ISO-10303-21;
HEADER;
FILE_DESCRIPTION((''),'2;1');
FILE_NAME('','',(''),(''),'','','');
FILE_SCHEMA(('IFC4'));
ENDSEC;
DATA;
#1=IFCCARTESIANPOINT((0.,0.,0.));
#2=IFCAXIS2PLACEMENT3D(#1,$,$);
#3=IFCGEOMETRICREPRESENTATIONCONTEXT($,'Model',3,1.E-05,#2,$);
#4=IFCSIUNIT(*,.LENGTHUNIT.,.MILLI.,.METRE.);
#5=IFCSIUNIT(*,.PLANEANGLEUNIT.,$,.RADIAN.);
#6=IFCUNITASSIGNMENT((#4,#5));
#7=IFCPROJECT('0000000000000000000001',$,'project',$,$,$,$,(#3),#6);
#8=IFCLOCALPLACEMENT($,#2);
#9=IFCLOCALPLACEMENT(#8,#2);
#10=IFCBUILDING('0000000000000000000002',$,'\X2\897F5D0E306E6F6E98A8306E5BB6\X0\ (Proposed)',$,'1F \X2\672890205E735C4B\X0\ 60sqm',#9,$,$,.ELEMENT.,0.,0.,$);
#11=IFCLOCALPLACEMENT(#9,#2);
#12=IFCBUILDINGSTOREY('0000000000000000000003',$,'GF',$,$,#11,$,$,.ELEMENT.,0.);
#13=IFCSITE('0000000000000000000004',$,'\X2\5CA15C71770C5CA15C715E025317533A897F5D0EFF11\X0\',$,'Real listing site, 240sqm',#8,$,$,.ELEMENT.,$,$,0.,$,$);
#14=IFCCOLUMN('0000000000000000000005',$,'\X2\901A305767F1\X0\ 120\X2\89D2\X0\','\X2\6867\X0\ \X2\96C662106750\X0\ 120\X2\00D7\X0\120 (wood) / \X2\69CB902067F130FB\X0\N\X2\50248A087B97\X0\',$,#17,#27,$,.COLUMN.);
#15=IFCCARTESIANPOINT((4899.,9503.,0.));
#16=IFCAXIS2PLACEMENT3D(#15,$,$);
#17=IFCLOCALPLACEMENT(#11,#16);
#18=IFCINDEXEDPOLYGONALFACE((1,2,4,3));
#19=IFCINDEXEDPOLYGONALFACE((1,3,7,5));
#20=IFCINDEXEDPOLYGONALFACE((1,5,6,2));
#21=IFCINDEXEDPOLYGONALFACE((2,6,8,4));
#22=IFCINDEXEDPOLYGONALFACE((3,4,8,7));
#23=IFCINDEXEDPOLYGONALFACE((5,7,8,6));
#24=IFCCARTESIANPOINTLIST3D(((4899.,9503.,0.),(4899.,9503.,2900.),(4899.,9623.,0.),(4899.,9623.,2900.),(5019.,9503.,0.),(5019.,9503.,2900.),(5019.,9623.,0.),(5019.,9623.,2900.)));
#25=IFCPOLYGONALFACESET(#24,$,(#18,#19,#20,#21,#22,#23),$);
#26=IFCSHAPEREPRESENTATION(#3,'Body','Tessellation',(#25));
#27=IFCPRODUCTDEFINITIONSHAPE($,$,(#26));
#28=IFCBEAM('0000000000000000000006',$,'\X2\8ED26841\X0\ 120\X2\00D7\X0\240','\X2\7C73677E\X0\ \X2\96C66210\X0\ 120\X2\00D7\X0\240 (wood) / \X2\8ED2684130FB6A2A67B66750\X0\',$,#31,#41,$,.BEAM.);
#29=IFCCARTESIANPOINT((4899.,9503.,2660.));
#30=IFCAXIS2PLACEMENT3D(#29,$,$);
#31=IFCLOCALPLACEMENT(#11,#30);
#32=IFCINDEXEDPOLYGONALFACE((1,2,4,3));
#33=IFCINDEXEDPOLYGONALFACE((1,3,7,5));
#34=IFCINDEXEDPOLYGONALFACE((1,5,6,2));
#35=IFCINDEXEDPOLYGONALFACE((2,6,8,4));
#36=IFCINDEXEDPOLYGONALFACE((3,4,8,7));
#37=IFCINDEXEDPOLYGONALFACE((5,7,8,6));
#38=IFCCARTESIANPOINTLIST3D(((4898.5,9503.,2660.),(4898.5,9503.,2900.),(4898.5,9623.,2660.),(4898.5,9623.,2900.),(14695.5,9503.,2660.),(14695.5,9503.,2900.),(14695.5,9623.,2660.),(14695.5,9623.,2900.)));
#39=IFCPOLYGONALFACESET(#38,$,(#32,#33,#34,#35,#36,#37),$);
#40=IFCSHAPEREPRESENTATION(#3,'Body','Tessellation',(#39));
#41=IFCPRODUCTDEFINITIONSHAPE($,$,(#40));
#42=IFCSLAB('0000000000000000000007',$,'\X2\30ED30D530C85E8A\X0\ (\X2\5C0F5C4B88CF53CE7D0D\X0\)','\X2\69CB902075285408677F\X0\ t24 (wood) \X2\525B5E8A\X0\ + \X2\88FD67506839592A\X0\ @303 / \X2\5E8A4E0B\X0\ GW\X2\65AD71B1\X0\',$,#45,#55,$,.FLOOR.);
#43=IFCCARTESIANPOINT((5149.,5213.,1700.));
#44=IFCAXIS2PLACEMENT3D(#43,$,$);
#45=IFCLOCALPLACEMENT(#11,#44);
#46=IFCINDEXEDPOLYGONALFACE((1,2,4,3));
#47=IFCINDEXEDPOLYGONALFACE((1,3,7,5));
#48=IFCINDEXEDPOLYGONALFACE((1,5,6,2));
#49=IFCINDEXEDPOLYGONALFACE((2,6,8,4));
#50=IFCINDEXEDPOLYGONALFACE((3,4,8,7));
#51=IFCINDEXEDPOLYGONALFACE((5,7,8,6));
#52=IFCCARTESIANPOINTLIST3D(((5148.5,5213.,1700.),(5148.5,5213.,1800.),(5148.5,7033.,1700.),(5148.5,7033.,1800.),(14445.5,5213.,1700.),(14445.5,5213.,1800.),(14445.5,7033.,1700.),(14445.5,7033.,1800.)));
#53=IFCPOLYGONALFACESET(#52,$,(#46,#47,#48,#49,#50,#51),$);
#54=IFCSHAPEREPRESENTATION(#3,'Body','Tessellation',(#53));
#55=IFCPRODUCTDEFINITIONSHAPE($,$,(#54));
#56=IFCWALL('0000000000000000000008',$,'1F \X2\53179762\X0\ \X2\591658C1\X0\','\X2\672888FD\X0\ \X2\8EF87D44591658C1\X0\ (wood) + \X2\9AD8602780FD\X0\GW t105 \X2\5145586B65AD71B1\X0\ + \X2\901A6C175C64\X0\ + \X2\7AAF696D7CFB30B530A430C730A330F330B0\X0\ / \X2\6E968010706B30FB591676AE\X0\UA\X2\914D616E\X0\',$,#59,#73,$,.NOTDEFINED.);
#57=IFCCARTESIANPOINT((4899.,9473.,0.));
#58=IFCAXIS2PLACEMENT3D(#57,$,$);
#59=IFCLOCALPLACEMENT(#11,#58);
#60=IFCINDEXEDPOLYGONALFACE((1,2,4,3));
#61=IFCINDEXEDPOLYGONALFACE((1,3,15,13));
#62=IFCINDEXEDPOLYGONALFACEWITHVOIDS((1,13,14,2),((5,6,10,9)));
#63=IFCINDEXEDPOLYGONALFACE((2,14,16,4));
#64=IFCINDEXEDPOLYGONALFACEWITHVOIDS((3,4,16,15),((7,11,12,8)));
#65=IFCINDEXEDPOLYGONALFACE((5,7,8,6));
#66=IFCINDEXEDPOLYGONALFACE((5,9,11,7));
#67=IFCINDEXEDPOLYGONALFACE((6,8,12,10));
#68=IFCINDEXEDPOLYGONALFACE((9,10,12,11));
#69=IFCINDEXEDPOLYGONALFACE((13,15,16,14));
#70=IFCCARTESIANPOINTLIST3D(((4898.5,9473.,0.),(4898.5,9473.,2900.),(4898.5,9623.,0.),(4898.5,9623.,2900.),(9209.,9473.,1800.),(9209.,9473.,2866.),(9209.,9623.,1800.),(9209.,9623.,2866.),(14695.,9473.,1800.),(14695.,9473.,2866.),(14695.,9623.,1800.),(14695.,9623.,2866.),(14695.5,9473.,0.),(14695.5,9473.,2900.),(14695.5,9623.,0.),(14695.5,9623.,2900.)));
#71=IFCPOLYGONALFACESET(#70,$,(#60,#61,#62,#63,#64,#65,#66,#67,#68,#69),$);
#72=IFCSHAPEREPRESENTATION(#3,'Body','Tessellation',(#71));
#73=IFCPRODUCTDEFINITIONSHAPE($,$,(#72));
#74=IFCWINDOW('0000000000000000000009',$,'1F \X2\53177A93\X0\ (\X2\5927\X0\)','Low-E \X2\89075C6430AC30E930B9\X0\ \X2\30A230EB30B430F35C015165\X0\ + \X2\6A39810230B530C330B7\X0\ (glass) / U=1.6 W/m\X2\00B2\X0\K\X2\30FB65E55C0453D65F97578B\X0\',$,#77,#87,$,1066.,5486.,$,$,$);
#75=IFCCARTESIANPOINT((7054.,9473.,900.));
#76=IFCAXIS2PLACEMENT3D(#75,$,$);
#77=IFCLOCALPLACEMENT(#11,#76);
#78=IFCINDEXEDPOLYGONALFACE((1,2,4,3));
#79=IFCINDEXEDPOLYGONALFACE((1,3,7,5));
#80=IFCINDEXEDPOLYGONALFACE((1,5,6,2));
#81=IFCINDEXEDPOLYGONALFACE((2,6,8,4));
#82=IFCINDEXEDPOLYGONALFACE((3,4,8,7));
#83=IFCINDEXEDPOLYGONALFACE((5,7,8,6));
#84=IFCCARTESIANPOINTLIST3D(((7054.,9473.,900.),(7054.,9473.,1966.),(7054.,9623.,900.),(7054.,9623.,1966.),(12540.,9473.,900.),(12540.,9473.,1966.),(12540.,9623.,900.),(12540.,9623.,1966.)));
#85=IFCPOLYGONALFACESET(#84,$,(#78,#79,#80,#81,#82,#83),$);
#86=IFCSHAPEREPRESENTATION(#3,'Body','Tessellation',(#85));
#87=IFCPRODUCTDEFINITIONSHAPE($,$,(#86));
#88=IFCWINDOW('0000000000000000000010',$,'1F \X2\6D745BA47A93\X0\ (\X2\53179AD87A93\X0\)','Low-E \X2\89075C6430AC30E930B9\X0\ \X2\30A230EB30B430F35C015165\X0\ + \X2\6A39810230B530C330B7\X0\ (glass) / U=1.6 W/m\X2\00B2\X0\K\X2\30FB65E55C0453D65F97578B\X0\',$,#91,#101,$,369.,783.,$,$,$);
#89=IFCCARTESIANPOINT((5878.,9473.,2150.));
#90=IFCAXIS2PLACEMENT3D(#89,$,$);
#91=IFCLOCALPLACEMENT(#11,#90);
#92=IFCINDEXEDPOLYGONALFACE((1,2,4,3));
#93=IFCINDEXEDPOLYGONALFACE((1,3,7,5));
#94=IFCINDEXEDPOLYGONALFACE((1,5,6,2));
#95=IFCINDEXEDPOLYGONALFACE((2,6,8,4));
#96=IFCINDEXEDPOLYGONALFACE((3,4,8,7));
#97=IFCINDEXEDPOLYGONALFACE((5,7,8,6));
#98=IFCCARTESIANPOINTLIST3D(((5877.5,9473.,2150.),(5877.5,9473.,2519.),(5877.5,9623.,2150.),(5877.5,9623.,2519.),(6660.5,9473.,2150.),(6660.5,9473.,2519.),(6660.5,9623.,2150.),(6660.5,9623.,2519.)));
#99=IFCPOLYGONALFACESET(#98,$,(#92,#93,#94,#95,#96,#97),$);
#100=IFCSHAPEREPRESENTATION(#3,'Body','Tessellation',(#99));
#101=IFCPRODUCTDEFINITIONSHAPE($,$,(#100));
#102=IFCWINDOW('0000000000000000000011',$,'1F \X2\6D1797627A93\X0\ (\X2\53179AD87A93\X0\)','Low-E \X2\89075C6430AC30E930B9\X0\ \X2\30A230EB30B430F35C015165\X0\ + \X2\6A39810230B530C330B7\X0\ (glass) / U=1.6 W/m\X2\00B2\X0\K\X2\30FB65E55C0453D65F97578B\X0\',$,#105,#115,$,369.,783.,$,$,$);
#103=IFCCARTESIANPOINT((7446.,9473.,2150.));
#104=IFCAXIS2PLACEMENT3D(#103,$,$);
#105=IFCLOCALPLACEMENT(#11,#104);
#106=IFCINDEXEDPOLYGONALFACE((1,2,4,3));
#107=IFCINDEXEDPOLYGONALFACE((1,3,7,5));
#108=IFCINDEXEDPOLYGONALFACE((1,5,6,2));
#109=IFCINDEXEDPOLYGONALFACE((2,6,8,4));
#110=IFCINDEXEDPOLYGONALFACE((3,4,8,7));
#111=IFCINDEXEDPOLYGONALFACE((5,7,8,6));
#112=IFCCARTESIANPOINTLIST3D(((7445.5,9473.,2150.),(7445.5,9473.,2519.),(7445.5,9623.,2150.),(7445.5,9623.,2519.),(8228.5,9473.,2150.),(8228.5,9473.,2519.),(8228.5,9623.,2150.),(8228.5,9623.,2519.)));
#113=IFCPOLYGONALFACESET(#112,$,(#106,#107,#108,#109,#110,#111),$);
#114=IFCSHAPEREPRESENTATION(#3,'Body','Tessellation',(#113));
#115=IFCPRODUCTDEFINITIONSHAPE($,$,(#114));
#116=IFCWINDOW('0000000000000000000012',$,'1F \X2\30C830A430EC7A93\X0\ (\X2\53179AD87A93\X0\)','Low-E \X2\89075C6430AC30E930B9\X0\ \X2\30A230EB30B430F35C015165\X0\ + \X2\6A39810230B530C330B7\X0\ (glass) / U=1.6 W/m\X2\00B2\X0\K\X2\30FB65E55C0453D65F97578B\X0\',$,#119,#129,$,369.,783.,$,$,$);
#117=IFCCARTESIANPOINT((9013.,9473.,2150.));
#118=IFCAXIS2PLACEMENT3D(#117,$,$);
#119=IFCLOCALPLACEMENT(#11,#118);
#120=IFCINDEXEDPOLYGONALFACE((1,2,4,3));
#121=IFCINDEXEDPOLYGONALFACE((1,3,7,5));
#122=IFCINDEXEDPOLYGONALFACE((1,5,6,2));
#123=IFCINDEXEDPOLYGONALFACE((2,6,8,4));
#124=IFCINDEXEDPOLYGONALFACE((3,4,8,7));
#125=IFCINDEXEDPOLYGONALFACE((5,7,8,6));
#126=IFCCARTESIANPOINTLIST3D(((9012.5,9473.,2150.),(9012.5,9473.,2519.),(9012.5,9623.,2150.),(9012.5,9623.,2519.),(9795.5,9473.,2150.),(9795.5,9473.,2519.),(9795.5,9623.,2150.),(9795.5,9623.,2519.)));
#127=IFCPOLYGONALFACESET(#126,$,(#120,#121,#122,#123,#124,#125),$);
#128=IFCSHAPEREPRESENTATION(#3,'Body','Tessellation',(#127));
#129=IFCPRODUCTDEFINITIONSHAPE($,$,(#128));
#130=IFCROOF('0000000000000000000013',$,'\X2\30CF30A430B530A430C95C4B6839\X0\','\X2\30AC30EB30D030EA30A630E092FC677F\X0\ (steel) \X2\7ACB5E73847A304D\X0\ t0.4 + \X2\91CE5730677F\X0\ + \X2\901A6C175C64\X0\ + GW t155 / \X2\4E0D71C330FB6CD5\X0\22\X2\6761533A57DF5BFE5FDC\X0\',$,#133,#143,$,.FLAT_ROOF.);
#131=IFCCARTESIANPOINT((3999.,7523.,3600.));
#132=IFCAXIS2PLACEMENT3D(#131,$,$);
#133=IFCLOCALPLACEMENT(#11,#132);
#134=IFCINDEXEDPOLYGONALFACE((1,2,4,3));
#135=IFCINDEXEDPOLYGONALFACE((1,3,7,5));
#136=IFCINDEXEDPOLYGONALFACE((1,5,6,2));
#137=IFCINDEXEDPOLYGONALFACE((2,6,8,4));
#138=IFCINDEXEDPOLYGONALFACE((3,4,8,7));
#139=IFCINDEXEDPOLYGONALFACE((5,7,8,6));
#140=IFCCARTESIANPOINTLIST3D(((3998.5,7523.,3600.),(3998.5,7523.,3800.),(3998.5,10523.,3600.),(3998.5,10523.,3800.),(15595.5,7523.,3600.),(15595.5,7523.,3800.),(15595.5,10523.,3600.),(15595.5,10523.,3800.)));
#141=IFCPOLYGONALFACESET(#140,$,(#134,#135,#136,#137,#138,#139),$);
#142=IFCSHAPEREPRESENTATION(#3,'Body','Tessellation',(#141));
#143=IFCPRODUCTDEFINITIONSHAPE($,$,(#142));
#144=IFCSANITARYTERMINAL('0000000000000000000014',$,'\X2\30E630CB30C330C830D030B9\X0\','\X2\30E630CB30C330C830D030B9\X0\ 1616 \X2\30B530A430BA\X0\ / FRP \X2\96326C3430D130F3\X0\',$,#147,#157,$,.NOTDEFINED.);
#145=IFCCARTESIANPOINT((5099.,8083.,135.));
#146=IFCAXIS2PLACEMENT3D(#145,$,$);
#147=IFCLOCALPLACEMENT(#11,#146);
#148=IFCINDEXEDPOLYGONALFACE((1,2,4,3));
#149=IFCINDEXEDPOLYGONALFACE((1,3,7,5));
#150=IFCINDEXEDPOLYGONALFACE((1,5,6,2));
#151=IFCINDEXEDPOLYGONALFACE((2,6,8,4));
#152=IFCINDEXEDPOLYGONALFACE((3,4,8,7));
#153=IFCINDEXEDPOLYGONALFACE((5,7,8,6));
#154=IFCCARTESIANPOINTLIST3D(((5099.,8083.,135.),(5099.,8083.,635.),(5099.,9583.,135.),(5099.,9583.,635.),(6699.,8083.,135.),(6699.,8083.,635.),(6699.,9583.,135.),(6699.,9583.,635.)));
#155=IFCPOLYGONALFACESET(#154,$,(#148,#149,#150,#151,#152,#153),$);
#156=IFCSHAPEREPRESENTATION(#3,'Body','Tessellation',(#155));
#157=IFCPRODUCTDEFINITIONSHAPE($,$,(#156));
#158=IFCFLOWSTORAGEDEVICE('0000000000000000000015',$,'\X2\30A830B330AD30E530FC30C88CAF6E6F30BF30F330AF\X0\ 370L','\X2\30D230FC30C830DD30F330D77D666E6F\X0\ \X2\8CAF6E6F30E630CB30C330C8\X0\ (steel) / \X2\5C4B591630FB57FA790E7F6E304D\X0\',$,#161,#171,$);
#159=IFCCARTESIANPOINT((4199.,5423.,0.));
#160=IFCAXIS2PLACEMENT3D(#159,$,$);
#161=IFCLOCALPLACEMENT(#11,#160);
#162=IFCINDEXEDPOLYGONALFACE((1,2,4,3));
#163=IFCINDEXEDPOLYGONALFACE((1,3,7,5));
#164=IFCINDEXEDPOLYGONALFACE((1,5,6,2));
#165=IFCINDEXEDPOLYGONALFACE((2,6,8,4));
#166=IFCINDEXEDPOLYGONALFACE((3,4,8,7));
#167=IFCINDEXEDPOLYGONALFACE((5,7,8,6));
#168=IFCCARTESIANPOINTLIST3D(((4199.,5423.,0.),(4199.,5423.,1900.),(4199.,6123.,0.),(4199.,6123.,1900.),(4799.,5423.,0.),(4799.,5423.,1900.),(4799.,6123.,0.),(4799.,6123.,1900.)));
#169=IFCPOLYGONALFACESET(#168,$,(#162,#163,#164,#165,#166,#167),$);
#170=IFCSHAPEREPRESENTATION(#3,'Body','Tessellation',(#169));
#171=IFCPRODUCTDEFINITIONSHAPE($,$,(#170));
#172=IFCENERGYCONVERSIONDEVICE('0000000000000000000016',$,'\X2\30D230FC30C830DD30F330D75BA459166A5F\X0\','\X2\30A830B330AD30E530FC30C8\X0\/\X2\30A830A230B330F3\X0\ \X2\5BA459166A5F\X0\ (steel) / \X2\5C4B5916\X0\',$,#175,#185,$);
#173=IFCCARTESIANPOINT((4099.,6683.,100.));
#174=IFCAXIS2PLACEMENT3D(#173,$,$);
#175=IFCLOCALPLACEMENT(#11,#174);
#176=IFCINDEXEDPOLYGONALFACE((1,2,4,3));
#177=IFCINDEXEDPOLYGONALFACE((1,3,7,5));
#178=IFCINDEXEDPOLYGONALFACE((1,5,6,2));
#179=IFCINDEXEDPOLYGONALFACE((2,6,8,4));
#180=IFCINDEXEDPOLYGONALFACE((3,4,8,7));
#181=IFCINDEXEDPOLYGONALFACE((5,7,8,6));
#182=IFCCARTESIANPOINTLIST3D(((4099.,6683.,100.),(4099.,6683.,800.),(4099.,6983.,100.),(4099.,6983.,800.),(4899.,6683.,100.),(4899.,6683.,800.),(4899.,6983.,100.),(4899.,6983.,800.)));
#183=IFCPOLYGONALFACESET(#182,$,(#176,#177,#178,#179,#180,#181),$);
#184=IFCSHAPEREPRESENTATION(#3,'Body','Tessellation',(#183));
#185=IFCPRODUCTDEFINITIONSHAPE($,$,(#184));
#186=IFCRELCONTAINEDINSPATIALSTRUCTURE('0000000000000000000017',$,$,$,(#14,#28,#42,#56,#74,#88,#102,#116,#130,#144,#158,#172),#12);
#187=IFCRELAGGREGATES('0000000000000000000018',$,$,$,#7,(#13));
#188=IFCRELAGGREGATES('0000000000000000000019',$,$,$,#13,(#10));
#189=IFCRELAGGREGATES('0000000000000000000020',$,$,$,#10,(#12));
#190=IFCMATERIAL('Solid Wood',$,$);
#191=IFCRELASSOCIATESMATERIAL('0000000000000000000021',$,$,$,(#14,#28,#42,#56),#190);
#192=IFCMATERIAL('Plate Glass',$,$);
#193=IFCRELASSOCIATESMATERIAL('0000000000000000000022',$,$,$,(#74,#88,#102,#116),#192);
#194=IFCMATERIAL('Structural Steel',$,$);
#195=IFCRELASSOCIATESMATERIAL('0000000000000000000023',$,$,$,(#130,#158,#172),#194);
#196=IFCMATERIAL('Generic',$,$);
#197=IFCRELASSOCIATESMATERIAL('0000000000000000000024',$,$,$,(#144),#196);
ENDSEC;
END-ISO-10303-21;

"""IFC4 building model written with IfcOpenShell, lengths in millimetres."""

from ifc_helpers import new_model, si_unit, frame, frame_2d, origin, place, context, project, spatial, rectangle, extrude, material, element, fill, save


model = new_model("IFC4")

# Units and contexts
model_context = context("Model", 3, precision=1e-05, world=origin())
ifc_project = project(units=[si_unit("LENGTHUNIT", "METRE", prefix="MILLI"), si_unit("PLANEANGLEUNIT", "RADIAN")], contexts=[model_context])

# Site, building, storey
site_placement = place(None, origin())
site = spatial("IfcSite", under=ifc_project, at=site_placement, Name="岡山県岡山市北区西崎１", ObjectType="Real listing site, 240sqm", CompositionType="ELEMENT", RefElevation=0.0)
building_placement = place(site_placement, origin())
building = spatial("IfcBuilding", under=site, at=building_placement, Name="西崎の潮風の家 (Proposed)", ObjectType="1F 木造平屋 60sqm", CompositionType="ELEMENT", ElevationOfRefHeight=0.0, ElevationOfTerrain=0.0)
storey_placement = place(building_placement, origin())
storey = spatial("IfcBuildingStorey", under=building, at=storey_placement, Name="GF", CompositionType="ELEMENT", Elevation=0.0)

# Column
ifc_material_1 = material(Name="Solid Wood")
column_1_placement = place(storey_placement, frame((4899.0, 9503.0, 0.0)))
element("IfcColumn", 1, at=column_1_placement, inside=storey, material=ifc_material_1, Name="通し柱 120角", Description="桧 集成材 120×120 (wood) / 構造柱・N値計算", PredefinedType="COLUMN", context=model_context, shape_type="SweptSolid", body=[
    extrude(rectangle(XDim=120.0, YDim=120.0, at=frame_2d((60.0, 60.0))), frame((4899.0, 9503.0, 0.0)), (0.0, 0.0, 1.0), 2900.0),
])

# Beam
beam_1_placement = place(storey_placement, frame((4899.0, 9503.0, 2660.0)))
element("IfcBeam", 2, at=beam_1_placement, inside=storey, material=ifc_material_1, Name="軒桁 120×240", Description="米松 集成 120×240 (wood) / 軒桁・横架材", PredefinedType="BEAM", context=model_context, shape_type="SweptSolid", body=[
    extrude(rectangle(XDim=9797.0, YDim=120.0, at=frame_2d((4898.0, 60.0))), frame((4899.0, 9503.0, 2660.0)), (0.0, 0.0, 1.0), 240.0),
])

# Slab
slab_placement = place(storey_placement, frame((5149.0, 5213.0, 1700.0)))
element("IfcSlab", 3, at=slab_placement, inside=storey, material=ifc_material_1, Name="ロフト床 (小屋裏収納)", Description="構造用合板 t24 (wood) 剛床 + 製材根太 @303 / 床下 GW断熱", PredefinedType="FLOOR", context=model_context, shape_type="SweptSolid", body=[
    extrude(rectangle(XDim=9297.0, YDim=1820.0, at=frame_2d((4648.0, 910.0))), frame((5149.0, 5213.0, 1700.0)), (0.0, 0.0, 1.0), 100.0),
])

# Wall, openings, windows
wall_1_placement = place(storey_placement, frame((4899.0, 9473.0, 0.0)))
wall_1 = element("IfcWall", 4, at=wall_1_placement, inside=storey, material=ifc_material_1, Name="1F 北面 外壁", Description="木製 軸組外壁 (wood) + 高性能GW t105 充填断熱 + 通気層 + 窯業系サイディング / 準耐火・外皮UA配慮", PredefinedType="NOTDEFINED", context=model_context, shape_type="SweptSolid", body=[
    extrude(rectangle(XDim=9797.0, YDim=150.0, at=frame_2d((4898.0, 75.0))), frame((4899.0, 9473.0, 0.0)), (0.0, 0.0, 1.0), 2900.0),
])
opening_1_placement = place(storey_placement, frame((7054.0, 9473.0, 900.0)))
opening_1 = element("IfcOpeningElement", 5, at=opening_1_placement, cuts=wall_1, PredefinedType="NOTDEFINED", context=model_context, shape_type="SweptSolid", body=[
    extrude(rectangle(XDim=5486.0, YDim=150.0, at=frame_2d((2743.0, 75.0))), frame((7054.0, 9473.0, 900.0)), (0.0, 0.0, 1.0), 1066.0),
])
opening_2_placement = place(storey_placement, frame((5878.0, 9473.0, 2150.0)))
opening_2 = element("IfcOpeningElement", 6, at=opening_2_placement, cuts=wall_1, PredefinedType="NOTDEFINED", context=model_context, shape_type="SweptSolid", body=[
    extrude(rectangle(XDim=783.0, YDim=150.0, at=frame_2d((391.0, 75.0))), frame((5878.0, 9473.0, 2150.0)), (0.0, 0.0, 1.0), 369.0),
])
opening_3_placement = place(storey_placement, frame((7446.0, 9473.0, 2150.0)))
opening_3 = element("IfcOpeningElement", 7, at=opening_3_placement, cuts=wall_1, PredefinedType="NOTDEFINED", context=model_context, shape_type="SweptSolid", body=[
    extrude(rectangle(XDim=783.0, YDim=150.0, at=frame_2d((391.0, 75.0))), frame((7446.0, 9473.0, 2150.0)), (0.0, 0.0, 1.0), 369.0),
])
opening_4_placement = place(storey_placement, frame((9013.0, 9473.0, 2150.0)))
opening_4 = element("IfcOpeningElement", 8, at=opening_4_placement, cuts=wall_1, PredefinedType="NOTDEFINED", context=model_context, shape_type="SweptSolid", body=[
    extrude(rectangle(XDim=783.0, YDim=150.0, at=frame_2d((391.0, 75.0))), frame((9013.0, 9473.0, 2150.0)), (0.0, 0.0, 1.0), 369.0),
])
ifc_material_2 = material(Name="Plate Glass")
window_1_placement = place(storey_placement, frame((7054.0, 9473.0, 900.0)))
window_1 = element("IfcWindow", 9, at=window_1_placement, inside=storey, material=ifc_material_2, Name="1F 北窓 (大)", Description="Low-E 複層ガラス アルゴン封入 + 樹脂サッシ (glass) / U=1.6 W/m²K・日射取得型", OverallHeight=1066.0, OverallWidth=5486.0, context=model_context, shape_type="SweptSolid", body=[
    extrude(rectangle(XDim=5486.0, YDim=150.0, at=frame_2d((2743.0, 75.0))), frame((7054.0, 9473.0, 900.0)), (0.0, 0.0, 1.0), 1066.0),
])
fill(opening_1, window_1)
window_2_placement = place(storey_placement, frame((5878.0, 9473.0, 2150.0)))
window_2 = element("IfcWindow", 10, at=window_2_placement, inside=storey, material=ifc_material_2, Name="1F 浴室窓 (北高窓)", Description="Low-E 複層ガラス アルゴン封入 + 樹脂サッシ (glass) / U=1.6 W/m²K・日射取得型", OverallHeight=369.0, OverallWidth=783.0, context=model_context, shape_type="SweptSolid", body=[
    extrude(rectangle(XDim=783.0, YDim=150.0, at=frame_2d((391.0, 75.0))), frame((5878.0, 9473.0, 2150.0)), (0.0, 0.0, 1.0), 369.0),
])
fill(opening_2, window_2)
window_3_placement = place(storey_placement, frame((7446.0, 9473.0, 2150.0)))
window_3 = element("IfcWindow", 11, at=window_3_placement, inside=storey, material=ifc_material_2, Name="1F 洗面窓 (北高窓)", Description="Low-E 複層ガラス アルゴン封入 + 樹脂サッシ (glass) / U=1.6 W/m²K・日射取得型", OverallHeight=369.0, OverallWidth=783.0, context=model_context, shape_type="SweptSolid", body=[
    extrude(rectangle(XDim=783.0, YDim=150.0, at=frame_2d((391.0, 75.0))), frame((7446.0, 9473.0, 2150.0)), (0.0, 0.0, 1.0), 369.0),
])
fill(opening_3, window_3)
window_4_placement = place(storey_placement, frame((9013.0, 9473.0, 2150.0)))
window_4 = element("IfcWindow", 12, at=window_4_placement, inside=storey, material=ifc_material_2, Name="1F トイレ窓 (北高窓)", Description="Low-E 複層ガラス アルゴン封入 + 樹脂サッシ (glass) / U=1.6 W/m²K・日射取得型", OverallHeight=369.0, OverallWidth=783.0, context=model_context, shape_type="SweptSolid", body=[
    extrude(rectangle(XDim=783.0, YDim=150.0, at=frame_2d((391.0, 75.0))), frame((9013.0, 9473.0, 2150.0)), (0.0, 0.0, 1.0), 369.0),
])
fill(opening_4, window_4)

# Roof
ifc_material_3 = material(Name="Structural Steel")
roof_placement = place(storey_placement, frame((3999.0, 7523.0, 3600.0)))
element("IfcRoof", 13, at=roof_placement, inside=storey, material=ifc_material_3, Name="ハイサイド屋根", Description="ガルバリウム鋼板 (steel) 立平葺き t0.4 + 野地板 + 通気層 + GW t155 / 不燃・法22条区域対応", PredefinedType="FLAT_ROOF", context=model_context, shape_type="SweptSolid", body=[
    extrude(rectangle(XDim=11597.0, YDim=3000.0, at=frame_2d((5798.0, 1500.0))), frame((3999.0, 7523.0, 3600.0)), (0.0, 0.0, 1.0), 200.0),
])

# Sanitary terminal
ifc_material_4 = material(Name="Generic")
sanitary_terminal_placement = place(storey_placement, frame((5099.0, 8083.0, 135.0)))
element("IfcSanitaryTerminal", 14, at=sanitary_terminal_placement, inside=storey, material=ifc_material_4, Name="ユニットバス", Description="ユニットバス 1616 サイズ / FRP 防水パン", PredefinedType="NOTDEFINED", context=model_context, shape_type="SweptSolid", body=[
    extrude(rectangle(XDim=1600.0, YDim=1500.0, at=frame_2d((800.0, 750.0))), frame((5099.0, 8083.0, 135.0)), (0.0, 0.0, 1.0), 500.0),
])

# Flow storage device
flow_storage_device_placement = place(storey_placement, frame((4199.0, 5423.0, 0.0)))
element("IfcFlowStorageDevice", 15, at=flow_storage_device_placement, inside=storey, material=ifc_material_3, Name="エコキュート貯湯タンク 370L", Description="ヒートポンプ給湯 貯湯ユニット (steel) / 屋外・基礎置き", context=model_context, shape_type="SweptSolid", body=[
    extrude(rectangle(XDim=600.0, YDim=700.0, at=frame_2d((300.0, 350.0))), frame((4199.0, 5423.0, 0.0)), (0.0, 0.0, 1.0), 1900.0),
])

# Energy conversion device
energy_conversion_device_placement = place(storey_placement, frame((4099.0, 6683.0, 100.0)))
element("IfcEnergyConversionDevice", 16, at=energy_conversion_device_placement, inside=storey, material=ifc_material_3, Name="ヒートポンプ室外機", Description="エコキュート/エアコン 室外機 (steel) / 屋外", context=model_context, shape_type="SweptSolid", body=[
    extrude(rectangle(XDim=800.0, YDim=300.0, at=frame_2d((400.0, 150.0))), frame((4099.0, 6683.0, 100.0)), (0.0, 0.0, 1.0), 700.0),
])

save(model, "model.ifc")
